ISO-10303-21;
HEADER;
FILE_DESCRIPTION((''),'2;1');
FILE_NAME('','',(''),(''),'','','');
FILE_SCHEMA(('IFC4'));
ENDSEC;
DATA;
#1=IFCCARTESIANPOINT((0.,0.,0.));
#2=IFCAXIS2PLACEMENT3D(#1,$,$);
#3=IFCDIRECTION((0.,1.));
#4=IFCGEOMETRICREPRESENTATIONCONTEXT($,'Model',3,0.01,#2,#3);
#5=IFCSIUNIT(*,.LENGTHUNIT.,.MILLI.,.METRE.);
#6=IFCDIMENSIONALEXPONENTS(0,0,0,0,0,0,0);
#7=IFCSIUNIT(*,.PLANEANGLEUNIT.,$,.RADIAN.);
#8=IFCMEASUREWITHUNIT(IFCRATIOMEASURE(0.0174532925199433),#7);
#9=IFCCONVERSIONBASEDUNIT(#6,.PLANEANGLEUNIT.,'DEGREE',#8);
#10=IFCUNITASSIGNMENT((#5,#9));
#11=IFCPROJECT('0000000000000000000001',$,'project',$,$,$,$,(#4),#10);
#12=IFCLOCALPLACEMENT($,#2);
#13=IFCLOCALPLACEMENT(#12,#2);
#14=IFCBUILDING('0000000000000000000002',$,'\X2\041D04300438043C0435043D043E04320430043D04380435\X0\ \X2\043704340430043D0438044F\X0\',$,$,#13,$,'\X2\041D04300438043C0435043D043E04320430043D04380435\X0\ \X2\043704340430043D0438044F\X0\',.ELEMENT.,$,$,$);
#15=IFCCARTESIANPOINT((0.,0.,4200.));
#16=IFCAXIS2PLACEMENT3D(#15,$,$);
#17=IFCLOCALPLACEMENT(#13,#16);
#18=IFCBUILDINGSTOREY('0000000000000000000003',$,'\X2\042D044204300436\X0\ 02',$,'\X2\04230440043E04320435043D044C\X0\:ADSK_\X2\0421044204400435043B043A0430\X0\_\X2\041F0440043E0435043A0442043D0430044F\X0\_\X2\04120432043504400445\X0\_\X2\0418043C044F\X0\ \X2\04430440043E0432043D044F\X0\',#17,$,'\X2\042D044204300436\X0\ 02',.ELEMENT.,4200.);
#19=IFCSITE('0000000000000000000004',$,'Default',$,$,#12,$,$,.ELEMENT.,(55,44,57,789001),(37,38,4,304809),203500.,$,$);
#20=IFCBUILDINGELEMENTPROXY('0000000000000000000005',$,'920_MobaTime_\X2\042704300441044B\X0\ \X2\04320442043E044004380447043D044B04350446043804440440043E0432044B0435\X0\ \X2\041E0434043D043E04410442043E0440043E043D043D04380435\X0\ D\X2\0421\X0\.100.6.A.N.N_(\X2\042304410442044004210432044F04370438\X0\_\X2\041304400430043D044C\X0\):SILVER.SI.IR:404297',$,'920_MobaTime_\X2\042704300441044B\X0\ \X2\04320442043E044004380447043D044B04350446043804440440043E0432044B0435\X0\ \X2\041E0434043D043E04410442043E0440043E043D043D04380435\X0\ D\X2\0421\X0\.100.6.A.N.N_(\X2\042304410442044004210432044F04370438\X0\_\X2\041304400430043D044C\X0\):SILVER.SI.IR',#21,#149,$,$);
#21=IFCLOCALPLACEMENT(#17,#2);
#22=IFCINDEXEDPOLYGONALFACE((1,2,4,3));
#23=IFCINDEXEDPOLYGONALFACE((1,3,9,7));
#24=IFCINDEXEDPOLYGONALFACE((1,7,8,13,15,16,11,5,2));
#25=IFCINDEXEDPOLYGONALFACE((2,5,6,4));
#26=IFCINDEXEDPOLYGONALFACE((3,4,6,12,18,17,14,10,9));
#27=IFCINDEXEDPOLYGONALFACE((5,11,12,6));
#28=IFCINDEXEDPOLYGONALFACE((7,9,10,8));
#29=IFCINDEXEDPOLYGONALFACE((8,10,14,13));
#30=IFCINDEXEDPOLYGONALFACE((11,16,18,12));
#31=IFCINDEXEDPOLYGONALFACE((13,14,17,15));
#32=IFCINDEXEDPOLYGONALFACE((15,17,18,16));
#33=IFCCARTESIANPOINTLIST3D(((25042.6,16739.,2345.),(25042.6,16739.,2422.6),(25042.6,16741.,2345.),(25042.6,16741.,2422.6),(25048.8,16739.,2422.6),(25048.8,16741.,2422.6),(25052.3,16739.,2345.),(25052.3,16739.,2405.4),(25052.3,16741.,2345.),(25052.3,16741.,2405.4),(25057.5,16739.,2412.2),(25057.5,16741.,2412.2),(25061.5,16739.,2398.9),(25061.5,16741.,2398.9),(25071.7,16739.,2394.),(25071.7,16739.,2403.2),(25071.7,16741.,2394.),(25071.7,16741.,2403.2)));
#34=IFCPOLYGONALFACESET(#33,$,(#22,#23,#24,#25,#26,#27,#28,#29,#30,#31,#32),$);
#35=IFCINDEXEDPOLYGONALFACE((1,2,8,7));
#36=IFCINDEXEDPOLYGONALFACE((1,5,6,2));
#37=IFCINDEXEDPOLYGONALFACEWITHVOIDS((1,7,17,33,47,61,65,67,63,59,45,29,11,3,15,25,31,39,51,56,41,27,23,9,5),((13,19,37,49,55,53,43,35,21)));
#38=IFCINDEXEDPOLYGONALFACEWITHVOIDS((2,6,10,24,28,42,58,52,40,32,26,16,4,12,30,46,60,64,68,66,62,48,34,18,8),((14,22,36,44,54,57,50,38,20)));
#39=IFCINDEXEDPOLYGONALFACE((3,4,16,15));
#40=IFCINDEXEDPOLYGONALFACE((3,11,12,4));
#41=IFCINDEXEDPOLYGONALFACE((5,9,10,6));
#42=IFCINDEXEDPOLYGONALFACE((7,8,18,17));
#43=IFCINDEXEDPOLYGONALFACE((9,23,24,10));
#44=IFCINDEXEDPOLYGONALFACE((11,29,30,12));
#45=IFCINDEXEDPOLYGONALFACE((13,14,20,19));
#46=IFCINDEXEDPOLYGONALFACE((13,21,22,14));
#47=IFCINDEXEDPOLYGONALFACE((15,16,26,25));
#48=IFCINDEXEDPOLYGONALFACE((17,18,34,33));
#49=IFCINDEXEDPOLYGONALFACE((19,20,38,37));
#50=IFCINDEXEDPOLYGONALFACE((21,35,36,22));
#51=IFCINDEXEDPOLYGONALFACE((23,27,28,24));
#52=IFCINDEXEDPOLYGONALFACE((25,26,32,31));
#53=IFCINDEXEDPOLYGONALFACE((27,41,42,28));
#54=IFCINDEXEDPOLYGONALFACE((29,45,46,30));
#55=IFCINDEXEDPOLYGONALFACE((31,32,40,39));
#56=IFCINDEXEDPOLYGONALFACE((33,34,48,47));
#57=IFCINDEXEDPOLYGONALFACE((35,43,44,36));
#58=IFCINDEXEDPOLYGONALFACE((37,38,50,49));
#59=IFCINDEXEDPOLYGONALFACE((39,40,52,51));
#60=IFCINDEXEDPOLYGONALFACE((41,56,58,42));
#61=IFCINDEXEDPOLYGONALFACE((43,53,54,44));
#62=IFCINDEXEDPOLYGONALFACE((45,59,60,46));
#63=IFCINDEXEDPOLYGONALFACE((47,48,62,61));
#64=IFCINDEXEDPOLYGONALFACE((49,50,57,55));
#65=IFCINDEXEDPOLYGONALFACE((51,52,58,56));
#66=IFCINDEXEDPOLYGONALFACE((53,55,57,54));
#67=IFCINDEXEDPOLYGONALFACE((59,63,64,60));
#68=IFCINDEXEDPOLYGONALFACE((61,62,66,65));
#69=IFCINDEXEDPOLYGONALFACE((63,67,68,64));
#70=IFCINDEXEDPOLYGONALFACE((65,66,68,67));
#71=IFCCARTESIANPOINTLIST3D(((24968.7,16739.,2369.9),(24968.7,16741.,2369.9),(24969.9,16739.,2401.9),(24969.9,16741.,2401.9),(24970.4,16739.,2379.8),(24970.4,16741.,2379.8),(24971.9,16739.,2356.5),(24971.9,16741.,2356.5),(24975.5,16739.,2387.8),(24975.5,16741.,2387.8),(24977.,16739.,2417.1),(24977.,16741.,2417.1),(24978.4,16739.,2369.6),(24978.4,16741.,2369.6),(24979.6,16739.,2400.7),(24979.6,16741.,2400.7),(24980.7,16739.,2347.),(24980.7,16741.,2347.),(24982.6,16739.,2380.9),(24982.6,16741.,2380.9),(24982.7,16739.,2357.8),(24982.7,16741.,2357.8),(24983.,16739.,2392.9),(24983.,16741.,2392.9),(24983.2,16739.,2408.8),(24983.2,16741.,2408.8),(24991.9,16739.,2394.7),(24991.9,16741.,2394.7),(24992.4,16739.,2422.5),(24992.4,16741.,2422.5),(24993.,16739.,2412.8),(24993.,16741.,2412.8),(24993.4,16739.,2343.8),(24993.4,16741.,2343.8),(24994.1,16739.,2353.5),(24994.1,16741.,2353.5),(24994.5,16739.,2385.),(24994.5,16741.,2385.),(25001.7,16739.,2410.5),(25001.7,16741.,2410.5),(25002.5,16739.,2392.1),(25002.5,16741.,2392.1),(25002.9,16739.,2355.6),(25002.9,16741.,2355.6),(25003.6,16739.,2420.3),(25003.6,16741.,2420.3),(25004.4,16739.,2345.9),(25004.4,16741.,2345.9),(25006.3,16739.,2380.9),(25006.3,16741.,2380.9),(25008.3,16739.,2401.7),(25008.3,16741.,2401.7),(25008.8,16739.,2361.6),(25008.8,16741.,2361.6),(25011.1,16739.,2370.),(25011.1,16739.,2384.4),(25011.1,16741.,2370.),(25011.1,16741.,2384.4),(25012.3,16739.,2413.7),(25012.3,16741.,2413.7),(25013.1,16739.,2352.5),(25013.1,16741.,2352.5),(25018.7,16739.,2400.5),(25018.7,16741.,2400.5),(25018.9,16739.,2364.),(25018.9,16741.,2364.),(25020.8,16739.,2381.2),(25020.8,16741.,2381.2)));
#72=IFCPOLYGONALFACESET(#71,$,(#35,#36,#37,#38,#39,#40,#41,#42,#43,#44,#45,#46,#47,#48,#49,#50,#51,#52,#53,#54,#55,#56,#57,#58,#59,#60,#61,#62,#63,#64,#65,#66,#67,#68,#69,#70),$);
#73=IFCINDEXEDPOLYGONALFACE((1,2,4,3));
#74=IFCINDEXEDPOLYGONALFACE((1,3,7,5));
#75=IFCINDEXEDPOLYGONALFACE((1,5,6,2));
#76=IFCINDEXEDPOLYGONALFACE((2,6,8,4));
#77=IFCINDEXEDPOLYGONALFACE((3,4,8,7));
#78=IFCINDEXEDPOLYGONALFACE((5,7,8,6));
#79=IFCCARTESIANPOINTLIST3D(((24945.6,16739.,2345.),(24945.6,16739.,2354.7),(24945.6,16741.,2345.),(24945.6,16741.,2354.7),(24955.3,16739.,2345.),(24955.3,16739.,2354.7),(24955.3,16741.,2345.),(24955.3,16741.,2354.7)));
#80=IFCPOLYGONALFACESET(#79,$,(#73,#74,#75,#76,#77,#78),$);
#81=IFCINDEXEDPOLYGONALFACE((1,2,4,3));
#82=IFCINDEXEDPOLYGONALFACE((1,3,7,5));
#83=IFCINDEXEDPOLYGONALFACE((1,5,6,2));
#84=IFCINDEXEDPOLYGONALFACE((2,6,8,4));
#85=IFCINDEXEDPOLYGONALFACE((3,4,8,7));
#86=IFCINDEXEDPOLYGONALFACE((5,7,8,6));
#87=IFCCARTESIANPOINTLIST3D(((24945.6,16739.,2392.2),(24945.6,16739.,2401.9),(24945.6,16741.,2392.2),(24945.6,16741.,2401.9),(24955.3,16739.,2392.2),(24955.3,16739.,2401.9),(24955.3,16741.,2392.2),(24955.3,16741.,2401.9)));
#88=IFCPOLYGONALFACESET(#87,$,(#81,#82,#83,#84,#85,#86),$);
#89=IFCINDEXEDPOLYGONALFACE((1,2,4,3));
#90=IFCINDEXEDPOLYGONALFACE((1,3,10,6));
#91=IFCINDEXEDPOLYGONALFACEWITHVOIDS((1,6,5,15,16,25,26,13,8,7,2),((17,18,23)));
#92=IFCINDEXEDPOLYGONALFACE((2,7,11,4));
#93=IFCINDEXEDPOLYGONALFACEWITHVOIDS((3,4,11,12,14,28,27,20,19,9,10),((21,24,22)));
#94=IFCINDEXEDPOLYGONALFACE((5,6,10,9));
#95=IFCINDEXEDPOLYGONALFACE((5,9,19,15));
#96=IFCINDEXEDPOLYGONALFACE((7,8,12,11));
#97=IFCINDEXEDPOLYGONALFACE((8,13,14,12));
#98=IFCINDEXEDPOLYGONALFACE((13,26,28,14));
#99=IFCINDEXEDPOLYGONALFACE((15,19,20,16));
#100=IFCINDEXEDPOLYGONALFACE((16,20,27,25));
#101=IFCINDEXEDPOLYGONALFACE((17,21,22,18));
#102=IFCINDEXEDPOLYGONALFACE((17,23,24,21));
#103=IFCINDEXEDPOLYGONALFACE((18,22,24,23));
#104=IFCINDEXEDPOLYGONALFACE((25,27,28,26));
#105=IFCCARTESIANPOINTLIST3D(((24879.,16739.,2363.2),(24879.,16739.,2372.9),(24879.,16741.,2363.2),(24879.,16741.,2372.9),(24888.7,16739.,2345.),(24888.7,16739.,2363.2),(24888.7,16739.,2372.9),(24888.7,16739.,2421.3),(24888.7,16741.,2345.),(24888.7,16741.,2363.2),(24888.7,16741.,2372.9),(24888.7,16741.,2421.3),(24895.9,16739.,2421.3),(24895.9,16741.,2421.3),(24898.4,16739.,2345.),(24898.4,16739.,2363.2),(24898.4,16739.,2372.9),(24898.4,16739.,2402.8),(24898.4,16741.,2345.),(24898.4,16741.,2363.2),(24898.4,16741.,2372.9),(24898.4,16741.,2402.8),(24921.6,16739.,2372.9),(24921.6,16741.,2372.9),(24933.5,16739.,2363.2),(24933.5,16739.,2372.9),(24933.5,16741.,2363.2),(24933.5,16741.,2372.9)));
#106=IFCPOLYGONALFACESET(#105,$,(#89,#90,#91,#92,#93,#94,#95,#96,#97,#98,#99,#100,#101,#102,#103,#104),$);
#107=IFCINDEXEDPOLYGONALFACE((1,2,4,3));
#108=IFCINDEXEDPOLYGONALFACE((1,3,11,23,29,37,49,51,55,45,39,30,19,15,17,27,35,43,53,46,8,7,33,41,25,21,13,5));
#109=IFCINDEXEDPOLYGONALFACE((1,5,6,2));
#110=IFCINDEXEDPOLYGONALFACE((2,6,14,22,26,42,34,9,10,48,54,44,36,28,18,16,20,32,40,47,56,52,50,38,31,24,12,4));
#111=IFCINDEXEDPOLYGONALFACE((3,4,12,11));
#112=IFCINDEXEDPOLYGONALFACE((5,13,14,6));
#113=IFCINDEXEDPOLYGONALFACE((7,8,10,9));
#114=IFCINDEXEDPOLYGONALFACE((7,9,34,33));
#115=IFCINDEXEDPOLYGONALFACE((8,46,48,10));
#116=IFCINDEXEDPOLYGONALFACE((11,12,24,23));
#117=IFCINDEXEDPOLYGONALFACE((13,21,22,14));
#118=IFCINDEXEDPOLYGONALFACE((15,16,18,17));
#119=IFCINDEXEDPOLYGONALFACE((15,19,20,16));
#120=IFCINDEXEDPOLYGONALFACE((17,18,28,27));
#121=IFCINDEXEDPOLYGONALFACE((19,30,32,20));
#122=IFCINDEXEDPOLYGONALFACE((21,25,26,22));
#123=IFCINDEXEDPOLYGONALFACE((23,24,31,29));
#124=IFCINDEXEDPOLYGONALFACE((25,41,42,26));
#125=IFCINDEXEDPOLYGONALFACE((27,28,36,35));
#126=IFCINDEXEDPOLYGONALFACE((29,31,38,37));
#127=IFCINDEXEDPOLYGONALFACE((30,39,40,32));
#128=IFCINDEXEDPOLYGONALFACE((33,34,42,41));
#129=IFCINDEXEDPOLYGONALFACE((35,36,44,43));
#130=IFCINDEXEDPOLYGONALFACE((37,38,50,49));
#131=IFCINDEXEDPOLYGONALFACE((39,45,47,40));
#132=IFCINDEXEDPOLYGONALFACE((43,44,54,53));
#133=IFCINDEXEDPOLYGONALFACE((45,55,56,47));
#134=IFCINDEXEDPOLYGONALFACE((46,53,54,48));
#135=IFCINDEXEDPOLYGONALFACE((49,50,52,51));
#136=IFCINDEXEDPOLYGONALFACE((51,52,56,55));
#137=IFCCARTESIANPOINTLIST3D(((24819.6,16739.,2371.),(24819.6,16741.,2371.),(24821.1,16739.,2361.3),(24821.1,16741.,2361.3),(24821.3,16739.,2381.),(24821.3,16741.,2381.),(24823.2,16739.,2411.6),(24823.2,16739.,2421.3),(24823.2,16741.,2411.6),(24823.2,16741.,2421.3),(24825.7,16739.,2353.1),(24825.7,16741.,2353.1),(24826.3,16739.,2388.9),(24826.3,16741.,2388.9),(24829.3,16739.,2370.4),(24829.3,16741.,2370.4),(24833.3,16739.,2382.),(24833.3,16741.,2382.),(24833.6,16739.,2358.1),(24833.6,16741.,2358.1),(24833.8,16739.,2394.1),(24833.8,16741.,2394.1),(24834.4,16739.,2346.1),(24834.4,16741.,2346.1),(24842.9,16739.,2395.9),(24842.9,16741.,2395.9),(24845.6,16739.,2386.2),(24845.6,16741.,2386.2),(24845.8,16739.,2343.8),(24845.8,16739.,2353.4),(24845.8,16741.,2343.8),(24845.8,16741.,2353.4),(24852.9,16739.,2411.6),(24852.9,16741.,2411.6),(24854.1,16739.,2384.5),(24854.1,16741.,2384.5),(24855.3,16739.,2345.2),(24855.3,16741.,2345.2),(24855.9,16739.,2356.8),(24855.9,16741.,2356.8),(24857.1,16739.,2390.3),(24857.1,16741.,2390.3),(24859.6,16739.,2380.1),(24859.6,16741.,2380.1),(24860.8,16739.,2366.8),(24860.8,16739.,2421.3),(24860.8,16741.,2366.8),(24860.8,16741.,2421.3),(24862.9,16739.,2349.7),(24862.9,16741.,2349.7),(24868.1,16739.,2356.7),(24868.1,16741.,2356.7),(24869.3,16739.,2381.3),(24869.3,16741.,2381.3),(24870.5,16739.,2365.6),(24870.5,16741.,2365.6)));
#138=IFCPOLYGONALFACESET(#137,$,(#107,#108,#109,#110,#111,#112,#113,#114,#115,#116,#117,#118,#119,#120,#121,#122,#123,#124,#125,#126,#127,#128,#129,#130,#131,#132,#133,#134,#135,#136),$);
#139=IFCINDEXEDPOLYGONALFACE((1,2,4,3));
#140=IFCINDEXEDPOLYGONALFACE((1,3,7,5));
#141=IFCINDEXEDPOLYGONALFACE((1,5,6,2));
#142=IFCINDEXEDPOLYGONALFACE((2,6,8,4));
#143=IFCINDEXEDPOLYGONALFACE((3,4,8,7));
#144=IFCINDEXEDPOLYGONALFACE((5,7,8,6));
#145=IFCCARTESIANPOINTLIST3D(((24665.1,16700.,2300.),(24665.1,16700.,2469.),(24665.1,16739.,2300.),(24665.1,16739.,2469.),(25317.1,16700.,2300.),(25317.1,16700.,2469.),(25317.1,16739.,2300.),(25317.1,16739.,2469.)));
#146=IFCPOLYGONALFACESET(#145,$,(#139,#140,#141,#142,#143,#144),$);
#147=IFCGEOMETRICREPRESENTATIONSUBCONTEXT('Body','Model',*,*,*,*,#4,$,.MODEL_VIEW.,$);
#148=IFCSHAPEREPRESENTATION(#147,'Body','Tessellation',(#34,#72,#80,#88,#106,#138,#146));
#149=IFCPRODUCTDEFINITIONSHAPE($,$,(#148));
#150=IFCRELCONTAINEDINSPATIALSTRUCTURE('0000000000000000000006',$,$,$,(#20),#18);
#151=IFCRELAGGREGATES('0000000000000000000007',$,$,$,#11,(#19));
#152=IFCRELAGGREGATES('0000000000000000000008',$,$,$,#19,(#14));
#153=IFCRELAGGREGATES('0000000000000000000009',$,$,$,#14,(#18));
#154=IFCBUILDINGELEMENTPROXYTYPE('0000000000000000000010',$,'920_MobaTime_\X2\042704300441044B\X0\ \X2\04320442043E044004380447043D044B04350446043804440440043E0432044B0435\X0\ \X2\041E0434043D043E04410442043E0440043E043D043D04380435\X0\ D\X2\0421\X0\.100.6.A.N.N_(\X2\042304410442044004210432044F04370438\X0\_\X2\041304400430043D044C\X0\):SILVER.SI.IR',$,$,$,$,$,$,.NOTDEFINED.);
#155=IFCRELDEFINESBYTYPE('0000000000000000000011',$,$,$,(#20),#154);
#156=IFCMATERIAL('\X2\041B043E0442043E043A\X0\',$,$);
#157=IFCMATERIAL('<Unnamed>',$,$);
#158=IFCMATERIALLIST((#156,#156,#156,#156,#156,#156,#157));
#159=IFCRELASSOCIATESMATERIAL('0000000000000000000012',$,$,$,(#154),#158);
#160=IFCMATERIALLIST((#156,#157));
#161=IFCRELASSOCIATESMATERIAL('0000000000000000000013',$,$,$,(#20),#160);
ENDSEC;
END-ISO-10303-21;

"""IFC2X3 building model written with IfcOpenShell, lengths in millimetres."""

from ifc_helpers import new_model, entity, si_unit, converted_unit, direction, frame, origin, origin_2d_with_axis, place, context, subcontext, project, spatial, polyline, rectangle, outline, extrude, source, transform, mapped, material, material_list, type_object, type_shapes, element, save


model = new_model("IFC2X3")

# Units and contexts
model_context = context("Model", 3, precision=0.01, world=origin(), true_north=direction((0.0, 1.0)))
body_context = subcontext(model_context, "Body", "Model", "MODEL_VIEW")
ifc_project = project(units=[si_unit("LENGTHUNIT", "METRE", prefix="MILLI"), converted_unit("PLANEANGLEUNIT", "DEGREE", entity("IfcRatioMeasure", 0.0174532925199433), si_unit("PLANEANGLEUNIT", "RADIAN"), dimensions=[0, 0, 0, 0, 0, 0, 0])], contexts=[model_context])

# Site, building, storey
site_placement = place(None, origin())
site = spatial("IfcSite", under=ifc_project, at=site_placement, Name="Default", CompositionType="ELEMENT", RefLatitude=(55, 44, 57, 789001), RefLongitude=(37, 38, 4, 304809), RefElevation=203500.0)
building_placement = place(site_placement, origin())
building = spatial("IfcBuilding", under=site, at=building_placement, Name="Наименование здания", LongName="Наименование здания", CompositionType="ELEMENT")
storey_placement = place(building_placement, frame((0.0, 0.0, 4200.0)))
storey = spatial("IfcBuildingStorey", under=building, at=storey_placement, Name="Этаж 02", ObjectType="Уровень:ADSK_Стрелка_Проектная_Вверх_Имя уровня", LongName="Этаж 02", CompositionType="ELEMENT", Elevation=4200.0)

# Building element proxy
ifc_material_1 = material(Name="Лоток")
ifc_material_2 = material(Name="<Unnamed>")
ifc_material_list_1 = material_list([ifc_material_1, ifc_material_2])
ifc_material_list_2 = material_list([ifc_material_1, ifc_material_1, ifc_material_1, ifc_material_1, ifc_material_1, ifc_material_1, ifc_material_2])
building_element_proxy_type_1 = type_object("IfcBuildingElementProxyType", Name="920_MobaTime_Часы вторичныецифровые Односторонние DС.100.6.A.N.N_(УстрСвязи_Грань):SILVER.SI.IR", PredefinedType="NOTDEFINED", material=ifc_material_list_2)
shared_shape_1 = source(origin(), body_context, "Body", "SweptSolid", [
    extrude(outline(polyline([(-49.3, -13.1), (28.2, -13.1), (28.2, -6.8), (17.9, 1.8), (8.8, 16.0), (-0.3, 16.0), (4.6, 5.8), (11.1, -3.4), (-49.3, -3.4), (-49.3, -13.1)])), frame((-64.6, 9.8, 39.0), z_axis=(0.0, 0.0, 1.0), x_axis=(0.0, 1.0, 0.0)), (0.0, 0.0, 1.0), 2.0),
    extrude(outline(polyline([(2.2, -27.6), (19.0, -27.6), (30.5, -16.1), (33.3, -4.9), (31.0, 5.8), (21.8, 17.2), (5.2, 27.3), (-11.1, 33.0), (-24.0, 32.7), (-33.6, 27.6), (-40.3, 18.6), (-42.8, 5.7), (-38.0, -6.3), (-27.2, -14.9), (-17.5, -17.7), (-8.2, -16.4), (-0.3, -11.9), (5.1, -4.5), (7.3, 6.2), (4.0, 17.2), (18.4, 7.3), (23.6, -2.4), (22.0, -11.4), (14.2, -18.4), (5.3, -18.3), (2.2, -27.6)]), holes=[polyline([(-9.0, 23.3), (-1.3, 14.3), (-2.5, 2.0), (-11.4, -7.0), (-23.4, -6.0), (-32.2, 2.9), (-31.2, 15.1), (-25.6, 22.1), (-17.5, 24.9), (-9.0, 23.3)])]), frame((-2.7, 3.6, 39.0), z_axis=(0.0, 0.0, 1.0), x_axis=(-0.427649, 0.903945, 0.0)), (0.0, 0.0, 1.0), 2.0),
    extrude(rectangle(XDim=9.7, YDim=9.7, at=origin_2d_with_axis()), frame((40.6, -34.7, 39.0)), (0.0, 0.0, 1.0), 2.0),
    extrude(rectangle(XDim=9.7, YDim=9.7, at=origin_2d_with_axis()), frame((40.6, 12.6, 39.0)), (0.0, 0.0, 1.0), 2.0),
    extrude(outline(polyline([(-0.9, -28.1), (8.8, -28.1), (8.8, -9.9), (18.5, -9.9), (18.5, -0.2), (8.8, -0.2), (8.8, 48.3), (1.5, 48.3), (-36.0, -0.2), (-36.0, -9.9), (-0.9, -9.9), (-0.9, -28.1)]), holes=[polyline([(-0.9, -0.2), (-24.1, -0.2), (-0.9, 29.7), (-0.9, -0.2)])]), frame((93.6, -11.4, 39.0)), (0.0, 0.0, 1.0), 2.0),
    extrude(outline(polyline([(3.3, -28.3), (12.5, -28.3), (20.5, -25.0), (26.8, -18.9), (30.7, -10.0), (31.4, 1.6), (26.9, 11.8), (20.1, 18.4), (11.1, 22.3), (1.0, 23.3), (-7.9, 20.4), (-14.9, 14.5), (-18.9, 6.2), (-17.1, -9.0), (-36.7, 0.5), (-29.1, 29.2), (-38.5, 31.7), (-48.1, -4.6), (-11.6, -23.1), (-8.0, -14.0), (-10.8, -7.6), (-10.2, 1.1), (-3.0, 11.8), (9.2, 12.8), (20.0, 5.5), (21.4, -7.5), (15.5, -16.4), (4.6, -18.6), (3.3, -28.3)])), frame((147.1, -8.5, 39.0), z_axis=(0.0, 0.0, 1.0), x_axis=(0.256974, -0.966418, 0.0)), (0.0, 0.0, 1.0), 2.0),
    extrude(rectangle(XDim=652.0, YDim=169.0, at=origin_2d_with_axis()), frame((0.0, 0.0, 0.0), z_axis=(0.0, 0.0, 1.0), x_axis=(-1.0, 0.0, 0.0)), (0.0, 0.0, 1.0), 39.0),
])
type_shapes(building_element_proxy_type_1, [shared_shape_1])
for number, where, z_axis, x_axis, name in (
    (1, (24991.1, 16700.0, 2384.5), (0.0, 1.0, 0.0), (-1.0, 0.0, 0.0), "920_MobaTime_Часы вторичныецифровые Односторонние DС.100.6.A.N.N_(УстрСвязи_Грань):SILVER.SI.IR:404297"),
):
    element("IfcBuildingElementProxy", number, at=place(storey_placement, frame(where, z_axis=z_axis, x_axis=x_axis)), inside=storey, type_object=building_element_proxy_type_1, material=ifc_material_list_1, Name=name, ObjectType="920_MobaTime_Часы вторичныецифровые Односторонние DС.100.6.A.N.N_(УстрСвязи_Грань):SILVER.SI.IR", context=body_context, shape_type="MappedRepresentation", body=[
        mapped(shared_shape_1, transform((0.0, 0.0, 0.0), scale=1.0)),
    ])

save(model, "model.ifc")
